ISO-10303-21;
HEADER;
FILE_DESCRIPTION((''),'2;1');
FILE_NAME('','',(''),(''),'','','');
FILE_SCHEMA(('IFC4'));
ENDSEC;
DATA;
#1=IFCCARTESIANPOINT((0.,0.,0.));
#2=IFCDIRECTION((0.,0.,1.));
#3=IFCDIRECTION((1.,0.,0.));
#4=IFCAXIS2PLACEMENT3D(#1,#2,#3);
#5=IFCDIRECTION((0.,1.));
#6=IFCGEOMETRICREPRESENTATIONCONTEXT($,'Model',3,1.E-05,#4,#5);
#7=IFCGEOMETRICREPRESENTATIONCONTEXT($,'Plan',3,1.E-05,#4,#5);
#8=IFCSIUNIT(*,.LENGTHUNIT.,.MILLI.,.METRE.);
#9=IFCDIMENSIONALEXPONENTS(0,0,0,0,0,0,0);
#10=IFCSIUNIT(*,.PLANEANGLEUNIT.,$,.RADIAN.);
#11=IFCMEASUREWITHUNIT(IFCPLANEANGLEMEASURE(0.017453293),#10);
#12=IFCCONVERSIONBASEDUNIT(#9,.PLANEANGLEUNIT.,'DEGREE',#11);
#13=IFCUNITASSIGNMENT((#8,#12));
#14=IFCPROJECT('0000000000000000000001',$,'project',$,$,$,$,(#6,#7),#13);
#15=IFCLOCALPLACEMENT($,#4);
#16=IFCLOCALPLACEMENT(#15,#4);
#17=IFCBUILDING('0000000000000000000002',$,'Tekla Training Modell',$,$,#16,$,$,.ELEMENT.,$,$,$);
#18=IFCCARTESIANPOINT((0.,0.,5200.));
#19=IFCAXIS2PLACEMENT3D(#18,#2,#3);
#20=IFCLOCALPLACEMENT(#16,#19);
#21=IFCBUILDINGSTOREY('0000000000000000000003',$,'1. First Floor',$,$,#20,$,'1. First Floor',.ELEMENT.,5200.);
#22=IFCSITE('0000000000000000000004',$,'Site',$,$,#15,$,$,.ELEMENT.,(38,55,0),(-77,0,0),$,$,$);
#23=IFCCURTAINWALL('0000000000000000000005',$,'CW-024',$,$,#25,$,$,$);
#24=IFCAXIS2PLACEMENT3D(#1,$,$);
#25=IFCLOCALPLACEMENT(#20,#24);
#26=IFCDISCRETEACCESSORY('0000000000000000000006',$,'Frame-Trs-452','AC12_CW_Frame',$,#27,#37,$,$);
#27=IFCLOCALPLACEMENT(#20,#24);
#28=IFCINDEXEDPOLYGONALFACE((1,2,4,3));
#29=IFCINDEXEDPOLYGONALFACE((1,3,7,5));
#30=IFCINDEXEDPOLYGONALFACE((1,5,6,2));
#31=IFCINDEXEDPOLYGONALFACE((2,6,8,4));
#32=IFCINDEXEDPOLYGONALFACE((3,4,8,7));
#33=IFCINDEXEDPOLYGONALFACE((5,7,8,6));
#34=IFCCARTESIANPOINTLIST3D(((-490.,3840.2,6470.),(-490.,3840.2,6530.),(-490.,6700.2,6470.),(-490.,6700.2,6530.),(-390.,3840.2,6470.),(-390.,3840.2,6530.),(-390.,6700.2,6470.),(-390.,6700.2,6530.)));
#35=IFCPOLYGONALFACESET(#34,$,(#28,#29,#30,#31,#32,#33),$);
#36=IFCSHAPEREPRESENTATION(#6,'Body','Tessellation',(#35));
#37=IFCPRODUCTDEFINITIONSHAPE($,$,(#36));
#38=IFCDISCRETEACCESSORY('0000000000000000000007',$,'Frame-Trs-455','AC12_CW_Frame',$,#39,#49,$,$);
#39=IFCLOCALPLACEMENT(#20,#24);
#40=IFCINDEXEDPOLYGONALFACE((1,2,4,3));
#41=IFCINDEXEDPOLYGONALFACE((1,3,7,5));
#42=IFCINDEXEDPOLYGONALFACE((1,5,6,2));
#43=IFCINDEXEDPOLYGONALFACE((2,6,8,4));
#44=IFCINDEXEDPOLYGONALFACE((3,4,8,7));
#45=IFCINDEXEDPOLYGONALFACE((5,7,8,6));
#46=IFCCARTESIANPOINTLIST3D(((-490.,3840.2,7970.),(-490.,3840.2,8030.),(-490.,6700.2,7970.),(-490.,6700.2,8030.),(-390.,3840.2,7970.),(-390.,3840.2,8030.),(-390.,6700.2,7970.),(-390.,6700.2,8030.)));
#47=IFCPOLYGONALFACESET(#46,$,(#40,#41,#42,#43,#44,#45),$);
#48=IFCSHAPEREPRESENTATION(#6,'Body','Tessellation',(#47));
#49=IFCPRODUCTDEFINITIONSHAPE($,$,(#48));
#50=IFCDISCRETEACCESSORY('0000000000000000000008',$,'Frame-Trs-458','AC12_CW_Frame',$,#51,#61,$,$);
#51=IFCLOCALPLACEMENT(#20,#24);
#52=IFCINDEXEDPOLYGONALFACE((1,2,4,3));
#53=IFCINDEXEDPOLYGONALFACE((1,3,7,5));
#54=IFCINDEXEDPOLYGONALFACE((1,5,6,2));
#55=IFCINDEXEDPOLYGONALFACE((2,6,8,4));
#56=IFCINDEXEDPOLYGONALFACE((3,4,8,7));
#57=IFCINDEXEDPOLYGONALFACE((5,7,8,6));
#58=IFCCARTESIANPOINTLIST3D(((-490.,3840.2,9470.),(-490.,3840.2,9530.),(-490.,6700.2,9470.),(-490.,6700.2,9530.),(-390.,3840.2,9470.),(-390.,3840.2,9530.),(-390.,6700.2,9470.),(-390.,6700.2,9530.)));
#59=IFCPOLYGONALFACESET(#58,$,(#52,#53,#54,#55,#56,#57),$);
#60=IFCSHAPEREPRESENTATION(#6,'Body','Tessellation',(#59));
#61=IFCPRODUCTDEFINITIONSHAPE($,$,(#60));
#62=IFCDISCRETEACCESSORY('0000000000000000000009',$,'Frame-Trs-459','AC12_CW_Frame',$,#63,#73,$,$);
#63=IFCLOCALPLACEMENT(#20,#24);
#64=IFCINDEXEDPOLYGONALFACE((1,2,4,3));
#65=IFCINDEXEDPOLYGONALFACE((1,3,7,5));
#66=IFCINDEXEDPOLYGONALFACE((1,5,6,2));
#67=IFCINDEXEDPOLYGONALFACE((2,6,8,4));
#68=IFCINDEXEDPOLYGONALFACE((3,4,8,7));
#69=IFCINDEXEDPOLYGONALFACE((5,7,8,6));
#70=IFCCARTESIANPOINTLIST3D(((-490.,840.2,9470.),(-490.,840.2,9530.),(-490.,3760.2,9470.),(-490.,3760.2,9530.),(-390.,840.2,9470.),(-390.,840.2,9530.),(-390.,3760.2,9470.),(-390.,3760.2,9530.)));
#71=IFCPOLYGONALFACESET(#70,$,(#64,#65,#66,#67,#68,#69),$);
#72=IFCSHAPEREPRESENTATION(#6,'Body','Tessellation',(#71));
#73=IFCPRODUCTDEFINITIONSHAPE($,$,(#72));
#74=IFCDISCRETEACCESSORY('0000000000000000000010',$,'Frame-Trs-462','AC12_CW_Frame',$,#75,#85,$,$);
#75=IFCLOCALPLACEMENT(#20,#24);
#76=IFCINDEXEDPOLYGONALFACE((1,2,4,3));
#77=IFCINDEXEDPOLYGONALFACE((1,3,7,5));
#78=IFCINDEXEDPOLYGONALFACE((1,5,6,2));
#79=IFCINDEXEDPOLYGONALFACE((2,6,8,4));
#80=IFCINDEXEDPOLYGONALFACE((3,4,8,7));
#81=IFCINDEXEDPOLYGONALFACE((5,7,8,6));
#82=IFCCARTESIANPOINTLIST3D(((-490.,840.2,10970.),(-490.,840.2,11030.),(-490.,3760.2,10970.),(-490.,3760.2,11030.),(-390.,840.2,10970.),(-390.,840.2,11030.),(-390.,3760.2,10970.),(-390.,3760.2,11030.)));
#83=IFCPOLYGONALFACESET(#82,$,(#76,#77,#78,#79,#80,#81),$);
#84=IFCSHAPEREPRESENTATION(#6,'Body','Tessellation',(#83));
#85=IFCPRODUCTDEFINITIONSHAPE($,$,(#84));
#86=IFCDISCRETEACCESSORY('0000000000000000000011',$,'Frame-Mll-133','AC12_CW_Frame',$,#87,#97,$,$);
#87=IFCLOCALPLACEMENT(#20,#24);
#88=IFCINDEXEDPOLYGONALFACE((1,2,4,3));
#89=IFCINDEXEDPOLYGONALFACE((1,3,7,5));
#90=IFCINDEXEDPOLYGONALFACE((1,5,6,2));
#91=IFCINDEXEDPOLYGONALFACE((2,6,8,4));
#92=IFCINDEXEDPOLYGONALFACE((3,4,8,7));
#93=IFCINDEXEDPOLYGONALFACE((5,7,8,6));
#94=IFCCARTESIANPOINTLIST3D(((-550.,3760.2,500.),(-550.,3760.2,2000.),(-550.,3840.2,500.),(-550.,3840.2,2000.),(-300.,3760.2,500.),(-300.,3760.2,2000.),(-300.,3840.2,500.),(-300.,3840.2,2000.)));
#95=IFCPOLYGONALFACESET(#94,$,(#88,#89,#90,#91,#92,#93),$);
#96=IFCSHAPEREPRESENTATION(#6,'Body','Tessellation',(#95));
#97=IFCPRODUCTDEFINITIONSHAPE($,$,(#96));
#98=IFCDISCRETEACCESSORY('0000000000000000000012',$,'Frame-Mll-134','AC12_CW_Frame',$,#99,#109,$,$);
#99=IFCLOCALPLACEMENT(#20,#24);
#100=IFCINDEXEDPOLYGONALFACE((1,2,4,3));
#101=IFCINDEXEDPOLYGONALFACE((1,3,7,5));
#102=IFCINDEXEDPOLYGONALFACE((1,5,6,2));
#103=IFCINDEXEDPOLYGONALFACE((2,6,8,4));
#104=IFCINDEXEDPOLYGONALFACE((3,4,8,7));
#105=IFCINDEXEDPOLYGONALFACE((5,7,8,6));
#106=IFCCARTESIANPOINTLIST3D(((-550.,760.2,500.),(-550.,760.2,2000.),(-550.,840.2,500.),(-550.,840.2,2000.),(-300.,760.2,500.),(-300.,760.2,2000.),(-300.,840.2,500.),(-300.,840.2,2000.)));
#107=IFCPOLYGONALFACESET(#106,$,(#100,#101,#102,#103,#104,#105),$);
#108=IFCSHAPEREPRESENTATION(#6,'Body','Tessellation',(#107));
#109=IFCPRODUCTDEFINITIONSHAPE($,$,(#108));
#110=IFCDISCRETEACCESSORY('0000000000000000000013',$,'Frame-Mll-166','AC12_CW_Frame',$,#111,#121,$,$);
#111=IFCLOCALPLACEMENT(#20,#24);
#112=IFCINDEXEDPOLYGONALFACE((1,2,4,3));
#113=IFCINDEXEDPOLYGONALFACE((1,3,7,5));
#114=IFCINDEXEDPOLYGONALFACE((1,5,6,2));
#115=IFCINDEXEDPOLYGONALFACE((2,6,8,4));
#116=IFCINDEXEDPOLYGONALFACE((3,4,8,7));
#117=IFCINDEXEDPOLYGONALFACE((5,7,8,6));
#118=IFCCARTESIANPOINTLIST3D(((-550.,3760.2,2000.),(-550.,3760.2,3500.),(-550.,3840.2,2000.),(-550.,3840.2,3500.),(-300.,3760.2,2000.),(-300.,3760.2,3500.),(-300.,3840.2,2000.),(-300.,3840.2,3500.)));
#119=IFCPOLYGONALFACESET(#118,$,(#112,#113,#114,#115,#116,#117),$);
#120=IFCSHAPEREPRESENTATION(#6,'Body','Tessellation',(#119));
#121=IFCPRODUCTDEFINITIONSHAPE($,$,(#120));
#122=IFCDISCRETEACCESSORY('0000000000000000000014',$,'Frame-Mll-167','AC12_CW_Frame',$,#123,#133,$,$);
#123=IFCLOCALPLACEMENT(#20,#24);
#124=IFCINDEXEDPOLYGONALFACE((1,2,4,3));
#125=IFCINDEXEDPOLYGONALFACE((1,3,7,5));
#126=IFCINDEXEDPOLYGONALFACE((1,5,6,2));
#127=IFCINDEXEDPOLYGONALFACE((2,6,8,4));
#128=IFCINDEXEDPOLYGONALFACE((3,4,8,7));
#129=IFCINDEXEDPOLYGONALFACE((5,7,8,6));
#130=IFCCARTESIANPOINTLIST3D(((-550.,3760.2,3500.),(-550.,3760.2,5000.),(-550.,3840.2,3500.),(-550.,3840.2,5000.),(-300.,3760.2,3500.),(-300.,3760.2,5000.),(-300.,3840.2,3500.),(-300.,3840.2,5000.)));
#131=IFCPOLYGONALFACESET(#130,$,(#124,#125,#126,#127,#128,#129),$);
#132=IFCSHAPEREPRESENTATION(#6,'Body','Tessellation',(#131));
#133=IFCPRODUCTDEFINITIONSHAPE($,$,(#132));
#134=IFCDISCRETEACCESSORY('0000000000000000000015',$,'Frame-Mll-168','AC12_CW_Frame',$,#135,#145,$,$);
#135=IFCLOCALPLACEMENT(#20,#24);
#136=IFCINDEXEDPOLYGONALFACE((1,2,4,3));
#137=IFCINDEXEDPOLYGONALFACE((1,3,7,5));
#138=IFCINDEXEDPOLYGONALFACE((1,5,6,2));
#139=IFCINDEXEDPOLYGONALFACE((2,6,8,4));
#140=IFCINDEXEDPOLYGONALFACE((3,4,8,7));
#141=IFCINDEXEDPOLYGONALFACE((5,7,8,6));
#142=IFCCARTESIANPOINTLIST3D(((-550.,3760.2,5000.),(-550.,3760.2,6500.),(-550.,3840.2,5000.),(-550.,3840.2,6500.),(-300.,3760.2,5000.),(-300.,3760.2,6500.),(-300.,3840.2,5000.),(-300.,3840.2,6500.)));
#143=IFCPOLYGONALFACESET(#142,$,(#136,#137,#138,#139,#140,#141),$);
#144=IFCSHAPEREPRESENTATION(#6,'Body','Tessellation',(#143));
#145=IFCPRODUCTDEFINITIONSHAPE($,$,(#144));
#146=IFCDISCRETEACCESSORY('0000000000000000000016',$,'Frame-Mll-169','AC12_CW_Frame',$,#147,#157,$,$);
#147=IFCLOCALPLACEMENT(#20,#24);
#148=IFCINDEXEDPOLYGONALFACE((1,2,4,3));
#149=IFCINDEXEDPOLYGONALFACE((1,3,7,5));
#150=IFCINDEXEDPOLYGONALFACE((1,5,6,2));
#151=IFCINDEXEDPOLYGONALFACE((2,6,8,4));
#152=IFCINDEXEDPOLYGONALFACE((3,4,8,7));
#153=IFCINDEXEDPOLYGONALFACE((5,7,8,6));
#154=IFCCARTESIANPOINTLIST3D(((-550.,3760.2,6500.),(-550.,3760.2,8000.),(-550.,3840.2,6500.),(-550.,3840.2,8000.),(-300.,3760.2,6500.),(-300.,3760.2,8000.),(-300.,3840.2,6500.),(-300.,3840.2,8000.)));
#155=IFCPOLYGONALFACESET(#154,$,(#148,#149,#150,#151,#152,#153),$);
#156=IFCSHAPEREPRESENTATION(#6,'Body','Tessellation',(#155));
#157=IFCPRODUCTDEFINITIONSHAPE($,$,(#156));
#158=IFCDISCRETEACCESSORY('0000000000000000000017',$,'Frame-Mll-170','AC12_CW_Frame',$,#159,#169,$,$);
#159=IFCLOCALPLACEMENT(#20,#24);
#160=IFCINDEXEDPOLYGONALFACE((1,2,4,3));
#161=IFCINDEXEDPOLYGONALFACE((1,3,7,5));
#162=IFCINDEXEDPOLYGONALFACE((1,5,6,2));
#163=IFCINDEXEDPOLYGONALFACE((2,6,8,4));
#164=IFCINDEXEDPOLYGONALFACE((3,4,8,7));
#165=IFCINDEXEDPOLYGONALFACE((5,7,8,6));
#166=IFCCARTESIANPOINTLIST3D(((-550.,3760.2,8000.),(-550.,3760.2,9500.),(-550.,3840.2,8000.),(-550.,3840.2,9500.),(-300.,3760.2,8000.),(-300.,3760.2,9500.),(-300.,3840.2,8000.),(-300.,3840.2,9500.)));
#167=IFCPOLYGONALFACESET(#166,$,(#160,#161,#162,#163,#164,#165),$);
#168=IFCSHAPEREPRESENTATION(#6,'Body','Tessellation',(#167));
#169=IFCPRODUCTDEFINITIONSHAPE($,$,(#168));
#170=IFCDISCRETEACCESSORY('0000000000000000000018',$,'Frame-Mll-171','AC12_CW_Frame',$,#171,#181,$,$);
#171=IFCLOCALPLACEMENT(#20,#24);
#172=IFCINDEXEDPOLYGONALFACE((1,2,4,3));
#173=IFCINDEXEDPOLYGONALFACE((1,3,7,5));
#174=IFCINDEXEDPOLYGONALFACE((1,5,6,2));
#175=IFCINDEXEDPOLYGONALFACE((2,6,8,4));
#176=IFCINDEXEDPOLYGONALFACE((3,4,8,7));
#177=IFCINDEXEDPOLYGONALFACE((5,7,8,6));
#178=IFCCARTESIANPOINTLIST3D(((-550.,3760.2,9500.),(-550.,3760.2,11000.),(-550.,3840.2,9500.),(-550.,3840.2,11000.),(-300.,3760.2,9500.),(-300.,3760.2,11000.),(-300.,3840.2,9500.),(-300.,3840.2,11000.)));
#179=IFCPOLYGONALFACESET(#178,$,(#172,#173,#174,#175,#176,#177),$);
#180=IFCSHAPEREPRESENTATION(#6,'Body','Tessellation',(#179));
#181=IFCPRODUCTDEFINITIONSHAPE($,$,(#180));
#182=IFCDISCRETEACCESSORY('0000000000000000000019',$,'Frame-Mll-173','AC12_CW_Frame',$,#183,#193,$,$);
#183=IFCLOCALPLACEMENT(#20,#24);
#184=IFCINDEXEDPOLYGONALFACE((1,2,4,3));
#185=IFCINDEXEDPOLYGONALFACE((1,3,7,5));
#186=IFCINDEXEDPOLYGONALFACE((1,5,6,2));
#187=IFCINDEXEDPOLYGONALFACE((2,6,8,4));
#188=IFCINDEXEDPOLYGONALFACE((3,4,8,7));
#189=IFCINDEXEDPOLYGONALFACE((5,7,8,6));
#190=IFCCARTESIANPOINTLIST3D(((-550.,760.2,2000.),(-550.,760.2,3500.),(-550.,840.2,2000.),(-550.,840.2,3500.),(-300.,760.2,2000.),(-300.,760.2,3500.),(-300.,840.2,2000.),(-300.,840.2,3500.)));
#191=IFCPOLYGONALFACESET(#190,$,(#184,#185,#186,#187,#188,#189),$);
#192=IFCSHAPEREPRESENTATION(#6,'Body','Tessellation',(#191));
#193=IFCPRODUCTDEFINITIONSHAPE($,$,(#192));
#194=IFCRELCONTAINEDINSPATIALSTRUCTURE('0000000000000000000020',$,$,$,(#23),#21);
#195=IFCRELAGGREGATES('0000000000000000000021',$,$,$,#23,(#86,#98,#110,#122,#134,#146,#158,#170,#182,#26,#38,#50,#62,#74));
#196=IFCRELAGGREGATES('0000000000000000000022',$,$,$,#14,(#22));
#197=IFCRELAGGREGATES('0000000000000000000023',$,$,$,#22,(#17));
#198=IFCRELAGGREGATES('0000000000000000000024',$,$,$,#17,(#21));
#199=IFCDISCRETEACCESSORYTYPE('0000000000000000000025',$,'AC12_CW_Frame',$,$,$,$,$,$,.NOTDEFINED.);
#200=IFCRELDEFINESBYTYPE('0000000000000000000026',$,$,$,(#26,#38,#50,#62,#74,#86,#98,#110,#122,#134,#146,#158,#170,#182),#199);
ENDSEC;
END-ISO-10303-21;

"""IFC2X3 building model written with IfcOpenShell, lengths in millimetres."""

from ifc_helpers import new_model, entity, si_unit, converted_unit, direction, frame, origin_with_axes, place, context, project, spatial, polyline, outline, extrude, source, transform, mapped, type_object, element, aggregate, save


model = new_model("IFC2X3")

# Units and contexts
model_context = context("Model", 3, precision=1e-05, world=origin_with_axes(), true_north=direction((0.0, 1.0)))
plan_context = context("Plan", 3, precision=1e-05, world=origin_with_axes(), true_north=direction((0.0, 1.0)))
ifc_project = project(units=[si_unit("LENGTHUNIT", "METRE", prefix="MILLI"), converted_unit("PLANEANGLEUNIT", "DEGREE", entity("IfcPlaneAngleMeasure", 0.017453293), si_unit("PLANEANGLEUNIT", "RADIAN"), dimensions=[0, 0, 0, 0, 0, 0, 0])], contexts=[model_context, plan_context])

# Site, building, storey
site_placement = place(None, origin_with_axes())
site = spatial("IfcSite", under=ifc_project, at=site_placement, Name="Site", CompositionType="ELEMENT", RefLatitude=(38, 55, 0), RefLongitude=(-77, 0, 0))
building_placement = place(site_placement, origin_with_axes())
building = spatial("IfcBuilding", under=site, at=building_placement, Name="Tekla Training Modell", CompositionType="ELEMENT")
storey_placement = place(building_placement, frame((0.0, 0.0, 5200.0), z_axis=(0.0, 0.0, 1.0), x_axis=(1.0, 0.0, 0.0)))
storey = spatial("IfcBuildingStorey", under=building, at=storey_placement, Name="1. First Floor", LongName="1. First Floor", CompositionType="ELEMENT", Elevation=5200.0)

# Curtain wall, discrete accessories
curtain_wall_placement = place(storey_placement, frame((-500.0, 6800.2, -1000.0), z_axis=(0.0, 0.0, 1.0), x_axis=(0.0, -1.0, 0.0)))
curtain_wall = element("IfcCurtainWall", 1, at=curtain_wall_placement, inside=storey, Name="CW-024")
discrete_accessory_type = type_object("IfcDiscreteAccessoryType", Name="AC12_CW_Frame")
shared_shape_1 = source(origin_with_axes(), model_context, "Body", "SweptSolid", [
    extrude(outline(polyline([(0.0, 0.0), (100.0, 0.0), (100.0, -2860.0), (0.0, -2860.0), (0.0, 0.0)])), origin_with_axes(), (0.0, 0.0, 1.0), 60.0),
])
discrete_accessory_1_placement = place(storey_placement, frame((-390.0, 6700.2, 6530.0), z_axis=(0.0, 0.0, -1.0), x_axis=(-1.0, 0.0, 0.0)))
discrete_accessory_1 = element("IfcDiscreteAccessory", 2, at=discrete_accessory_1_placement, type_object=discrete_accessory_type, Name="Frame-Trs-452", Description="AC12_CW_Frame", context=model_context, shape_type="MappedRepresentation", body=[
    mapped(shared_shape_1, transform((0.0, 0.0, 0.0), scale=1.0)),
])
discrete_accessory_2_placement = place(storey_placement, frame((-390.0, 6700.2, 8030.0), z_axis=(0.0, 0.0, -1.0), x_axis=(-1.0, 0.0, 0.0)))
discrete_accessory_2 = element("IfcDiscreteAccessory", 3, at=discrete_accessory_2_placement, type_object=discrete_accessory_type, Name="Frame-Trs-455", Description="AC12_CW_Frame", context=model_context, shape_type="MappedRepresentation", body=[
    mapped(shared_shape_1, transform((0.0, 0.0, 0.0), scale=1.0)),
])
discrete_accessory_3_placement = place(storey_placement, frame((-390.0, 6700.2, 9530.0), z_axis=(0.0, 0.0, -1.0), x_axis=(-1.0, 0.0, 0.0)))
discrete_accessory_3 = element("IfcDiscreteAccessory", 4, at=discrete_accessory_3_placement, type_object=discrete_accessory_type, Name="Frame-Trs-458", Description="AC12_CW_Frame", context=model_context, shape_type="MappedRepresentation", body=[
    mapped(shared_shape_1, transform((0.0, 0.0, 0.0), scale=1.0)),
])
shared_shape_2 = source(origin_with_axes(), model_context, "Body", "SweptSolid", [
    extrude(outline(polyline([(0.0, 0.0), (100.0, 0.0), (100.0, -2920.0), (0.0, -2920.0), (0.0, 0.0)])), origin_with_axes(), (0.0, 0.0, 1.0), 60.0),
])
discrete_accessory_4_placement = place(storey_placement, frame((-390.0, 3760.2, 9530.0), z_axis=(0.0, 0.0, -1.0), x_axis=(-1.0, 0.0, 0.0)))
discrete_accessory_4 = element("IfcDiscreteAccessory", 5, at=discrete_accessory_4_placement, type_object=discrete_accessory_type, Name="Frame-Trs-459", Description="AC12_CW_Frame", context=model_context, shape_type="MappedRepresentation", body=[
    mapped(shared_shape_2, transform((0.0, 0.0, 0.0), scale=1.0)),
])
discrete_accessory_5_placement = place(storey_placement, frame((-390.0, 3760.2, 11030.0), z_axis=(0.0, 0.0, -1.0), x_axis=(-1.0, 0.0, 0.0)))
discrete_accessory_5 = element("IfcDiscreteAccessory", 6, at=discrete_accessory_5_placement, type_object=discrete_accessory_type, Name="Frame-Trs-462", Description="AC12_CW_Frame", context=model_context, shape_type="MappedRepresentation", body=[
    mapped(shared_shape_2, transform((0.0, 0.0, 0.0), scale=1.0)),
])
shared_shape_3 = source(origin_with_axes(), model_context, "Body", "SweptSolid", [
    extrude(outline(polyline([(0.0, 0.0), (250.0, 0.0), (250.0, -1500.0), (0.0, -1500.0), (0.0, 0.0)])), origin_with_axes(), (0.0, 0.0, 1.0), 80.0),
])
discrete_accessory_6_placement = place(storey_placement, frame((-300.0, 3840.2, 500.0), z_axis=(0.0, -1.0, 0.0), x_axis=(-1.0, 0.0, 0.0)))
discrete_accessory_6 = element("IfcDiscreteAccessory", 7, at=discrete_accessory_6_placement, type_object=discrete_accessory_type, Name="Frame-Mll-133", Description="AC12_CW_Frame", context=model_context, shape_type="MappedRepresentation", body=[
    mapped(shared_shape_3, transform((0.0, 0.0, 0.0), scale=1.0)),
])
discrete_accessory_7_placement = place(storey_placement, frame((-300.0, 840.2, 500.0), z_axis=(0.0, -1.0, 0.0), x_axis=(-1.0, 0.0, 0.0)))
discrete_accessory_7 = element("IfcDiscreteAccessory", 8, at=discrete_accessory_7_placement, type_object=discrete_accessory_type, Name="Frame-Mll-134", Description="AC12_CW_Frame", context=model_context, shape_type="MappedRepresentation", body=[
    mapped(shared_shape_3, transform((0.0, 0.0, 0.0), scale=1.0)),
])
discrete_accessory_8_placement = place(storey_placement, frame((-300.0, 3840.2, 2000.0), z_axis=(0.0, -1.0, 0.0), x_axis=(-1.0, 0.0, 0.0)))
discrete_accessory_8 = element("IfcDiscreteAccessory", 9, at=discrete_accessory_8_placement, type_object=discrete_accessory_type, Name="Frame-Mll-166", Description="AC12_CW_Frame", context=model_context, shape_type="MappedRepresentation", body=[
    mapped(shared_shape_3, transform((0.0, 0.0, 0.0), scale=1.0)),
])
discrete_accessory_9_placement = place(storey_placement, frame((-300.0, 3840.2, 3500.0), z_axis=(0.0, -1.0, 0.0), x_axis=(-1.0, 0.0, 0.0)))
discrete_accessory_9 = element("IfcDiscreteAccessory", 10, at=discrete_accessory_9_placement, type_object=discrete_accessory_type, Name="Frame-Mll-167", Description="AC12_CW_Frame", context=model_context, shape_type="MappedRepresentation", body=[
    mapped(shared_shape_3, transform((0.0, 0.0, 0.0), scale=1.0)),
])
discrete_accessory_10_placement = place(storey_placement, frame((-300.0, 3840.2, 5000.0), z_axis=(0.0, -1.0, 0.0), x_axis=(-1.0, 0.0, 0.0)))
discrete_accessory_10 = element("IfcDiscreteAccessory", 11, at=discrete_accessory_10_placement, type_object=discrete_accessory_type, Name="Frame-Mll-168", Description="AC12_CW_Frame", context=model_context, shape_type="MappedRepresentation", body=[
    mapped(shared_shape_3, transform((0.0, 0.0, 0.0), scale=1.0)),
])
discrete_accessory_11_placement = place(storey_placement, frame((-300.0, 3840.2, 6500.0), z_axis=(0.0, -1.0, 0.0), x_axis=(-1.0, 0.0, 0.0)))
discrete_accessory_11 = element("IfcDiscreteAccessory", 12, at=discrete_accessory_11_placement, type_object=discrete_accessory_type, Name="Frame-Mll-169", Description="AC12_CW_Frame", context=model_context, shape_type="MappedRepresentation", body=[
    mapped(shared_shape_3, transform((0.0, 0.0, 0.0), scale=1.0)),
])
discrete_accessory_12_placement = place(storey_placement, frame((-300.0, 3840.2, 8000.0), z_axis=(0.0, -1.0, 0.0), x_axis=(-1.0, 0.0, 0.0)))
discrete_accessory_12 = element("IfcDiscreteAccessory", 13, at=discrete_accessory_12_placement, type_object=discrete_accessory_type, Name="Frame-Mll-170", Description="AC12_CW_Frame", context=model_context, shape_type="MappedRepresentation", body=[
    mapped(shared_shape_3, transform((0.0, 0.0, 0.0), scale=1.0)),
])
discrete_accessory_13_placement = place(storey_placement, frame((-300.0, 3840.2, 9500.0), z_axis=(0.0, -1.0, 0.0), x_axis=(-1.0, 0.0, 0.0)))
discrete_accessory_13 = element("IfcDiscreteAccessory", 14, at=discrete_accessory_13_placement, type_object=discrete_accessory_type, Name="Frame-Mll-171", Description="AC12_CW_Frame", context=model_context, shape_type="MappedRepresentation", body=[
    mapped(shared_shape_3, transform((0.0, 0.0, 0.0), scale=1.0)),
])
discrete_accessory_14_placement = place(storey_placement, frame((-300.0, 840.2, 2000.0), z_axis=(0.0, -1.0, 0.0), x_axis=(-1.0, 0.0, 0.0)))
discrete_accessory_14 = element("IfcDiscreteAccessory", 15, at=discrete_accessory_14_placement, type_object=discrete_accessory_type, Name="Frame-Mll-173", Description="AC12_CW_Frame", context=model_context, shape_type="MappedRepresentation", body=[
    mapped(shared_shape_3, transform((0.0, 0.0, 0.0), scale=1.0)),
])
aggregate(curtain_wall, [discrete_accessory_6, discrete_accessory_7, discrete_accessory_8, discrete_accessory_9, discrete_accessory_10, discrete_accessory_11, discrete_accessory_12, discrete_accessory_13, discrete_accessory_14, discrete_accessory_1, discrete_accessory_2, discrete_accessory_3, discrete_accessory_4, discrete_accessory_5])

save(model, "model.ifc")
